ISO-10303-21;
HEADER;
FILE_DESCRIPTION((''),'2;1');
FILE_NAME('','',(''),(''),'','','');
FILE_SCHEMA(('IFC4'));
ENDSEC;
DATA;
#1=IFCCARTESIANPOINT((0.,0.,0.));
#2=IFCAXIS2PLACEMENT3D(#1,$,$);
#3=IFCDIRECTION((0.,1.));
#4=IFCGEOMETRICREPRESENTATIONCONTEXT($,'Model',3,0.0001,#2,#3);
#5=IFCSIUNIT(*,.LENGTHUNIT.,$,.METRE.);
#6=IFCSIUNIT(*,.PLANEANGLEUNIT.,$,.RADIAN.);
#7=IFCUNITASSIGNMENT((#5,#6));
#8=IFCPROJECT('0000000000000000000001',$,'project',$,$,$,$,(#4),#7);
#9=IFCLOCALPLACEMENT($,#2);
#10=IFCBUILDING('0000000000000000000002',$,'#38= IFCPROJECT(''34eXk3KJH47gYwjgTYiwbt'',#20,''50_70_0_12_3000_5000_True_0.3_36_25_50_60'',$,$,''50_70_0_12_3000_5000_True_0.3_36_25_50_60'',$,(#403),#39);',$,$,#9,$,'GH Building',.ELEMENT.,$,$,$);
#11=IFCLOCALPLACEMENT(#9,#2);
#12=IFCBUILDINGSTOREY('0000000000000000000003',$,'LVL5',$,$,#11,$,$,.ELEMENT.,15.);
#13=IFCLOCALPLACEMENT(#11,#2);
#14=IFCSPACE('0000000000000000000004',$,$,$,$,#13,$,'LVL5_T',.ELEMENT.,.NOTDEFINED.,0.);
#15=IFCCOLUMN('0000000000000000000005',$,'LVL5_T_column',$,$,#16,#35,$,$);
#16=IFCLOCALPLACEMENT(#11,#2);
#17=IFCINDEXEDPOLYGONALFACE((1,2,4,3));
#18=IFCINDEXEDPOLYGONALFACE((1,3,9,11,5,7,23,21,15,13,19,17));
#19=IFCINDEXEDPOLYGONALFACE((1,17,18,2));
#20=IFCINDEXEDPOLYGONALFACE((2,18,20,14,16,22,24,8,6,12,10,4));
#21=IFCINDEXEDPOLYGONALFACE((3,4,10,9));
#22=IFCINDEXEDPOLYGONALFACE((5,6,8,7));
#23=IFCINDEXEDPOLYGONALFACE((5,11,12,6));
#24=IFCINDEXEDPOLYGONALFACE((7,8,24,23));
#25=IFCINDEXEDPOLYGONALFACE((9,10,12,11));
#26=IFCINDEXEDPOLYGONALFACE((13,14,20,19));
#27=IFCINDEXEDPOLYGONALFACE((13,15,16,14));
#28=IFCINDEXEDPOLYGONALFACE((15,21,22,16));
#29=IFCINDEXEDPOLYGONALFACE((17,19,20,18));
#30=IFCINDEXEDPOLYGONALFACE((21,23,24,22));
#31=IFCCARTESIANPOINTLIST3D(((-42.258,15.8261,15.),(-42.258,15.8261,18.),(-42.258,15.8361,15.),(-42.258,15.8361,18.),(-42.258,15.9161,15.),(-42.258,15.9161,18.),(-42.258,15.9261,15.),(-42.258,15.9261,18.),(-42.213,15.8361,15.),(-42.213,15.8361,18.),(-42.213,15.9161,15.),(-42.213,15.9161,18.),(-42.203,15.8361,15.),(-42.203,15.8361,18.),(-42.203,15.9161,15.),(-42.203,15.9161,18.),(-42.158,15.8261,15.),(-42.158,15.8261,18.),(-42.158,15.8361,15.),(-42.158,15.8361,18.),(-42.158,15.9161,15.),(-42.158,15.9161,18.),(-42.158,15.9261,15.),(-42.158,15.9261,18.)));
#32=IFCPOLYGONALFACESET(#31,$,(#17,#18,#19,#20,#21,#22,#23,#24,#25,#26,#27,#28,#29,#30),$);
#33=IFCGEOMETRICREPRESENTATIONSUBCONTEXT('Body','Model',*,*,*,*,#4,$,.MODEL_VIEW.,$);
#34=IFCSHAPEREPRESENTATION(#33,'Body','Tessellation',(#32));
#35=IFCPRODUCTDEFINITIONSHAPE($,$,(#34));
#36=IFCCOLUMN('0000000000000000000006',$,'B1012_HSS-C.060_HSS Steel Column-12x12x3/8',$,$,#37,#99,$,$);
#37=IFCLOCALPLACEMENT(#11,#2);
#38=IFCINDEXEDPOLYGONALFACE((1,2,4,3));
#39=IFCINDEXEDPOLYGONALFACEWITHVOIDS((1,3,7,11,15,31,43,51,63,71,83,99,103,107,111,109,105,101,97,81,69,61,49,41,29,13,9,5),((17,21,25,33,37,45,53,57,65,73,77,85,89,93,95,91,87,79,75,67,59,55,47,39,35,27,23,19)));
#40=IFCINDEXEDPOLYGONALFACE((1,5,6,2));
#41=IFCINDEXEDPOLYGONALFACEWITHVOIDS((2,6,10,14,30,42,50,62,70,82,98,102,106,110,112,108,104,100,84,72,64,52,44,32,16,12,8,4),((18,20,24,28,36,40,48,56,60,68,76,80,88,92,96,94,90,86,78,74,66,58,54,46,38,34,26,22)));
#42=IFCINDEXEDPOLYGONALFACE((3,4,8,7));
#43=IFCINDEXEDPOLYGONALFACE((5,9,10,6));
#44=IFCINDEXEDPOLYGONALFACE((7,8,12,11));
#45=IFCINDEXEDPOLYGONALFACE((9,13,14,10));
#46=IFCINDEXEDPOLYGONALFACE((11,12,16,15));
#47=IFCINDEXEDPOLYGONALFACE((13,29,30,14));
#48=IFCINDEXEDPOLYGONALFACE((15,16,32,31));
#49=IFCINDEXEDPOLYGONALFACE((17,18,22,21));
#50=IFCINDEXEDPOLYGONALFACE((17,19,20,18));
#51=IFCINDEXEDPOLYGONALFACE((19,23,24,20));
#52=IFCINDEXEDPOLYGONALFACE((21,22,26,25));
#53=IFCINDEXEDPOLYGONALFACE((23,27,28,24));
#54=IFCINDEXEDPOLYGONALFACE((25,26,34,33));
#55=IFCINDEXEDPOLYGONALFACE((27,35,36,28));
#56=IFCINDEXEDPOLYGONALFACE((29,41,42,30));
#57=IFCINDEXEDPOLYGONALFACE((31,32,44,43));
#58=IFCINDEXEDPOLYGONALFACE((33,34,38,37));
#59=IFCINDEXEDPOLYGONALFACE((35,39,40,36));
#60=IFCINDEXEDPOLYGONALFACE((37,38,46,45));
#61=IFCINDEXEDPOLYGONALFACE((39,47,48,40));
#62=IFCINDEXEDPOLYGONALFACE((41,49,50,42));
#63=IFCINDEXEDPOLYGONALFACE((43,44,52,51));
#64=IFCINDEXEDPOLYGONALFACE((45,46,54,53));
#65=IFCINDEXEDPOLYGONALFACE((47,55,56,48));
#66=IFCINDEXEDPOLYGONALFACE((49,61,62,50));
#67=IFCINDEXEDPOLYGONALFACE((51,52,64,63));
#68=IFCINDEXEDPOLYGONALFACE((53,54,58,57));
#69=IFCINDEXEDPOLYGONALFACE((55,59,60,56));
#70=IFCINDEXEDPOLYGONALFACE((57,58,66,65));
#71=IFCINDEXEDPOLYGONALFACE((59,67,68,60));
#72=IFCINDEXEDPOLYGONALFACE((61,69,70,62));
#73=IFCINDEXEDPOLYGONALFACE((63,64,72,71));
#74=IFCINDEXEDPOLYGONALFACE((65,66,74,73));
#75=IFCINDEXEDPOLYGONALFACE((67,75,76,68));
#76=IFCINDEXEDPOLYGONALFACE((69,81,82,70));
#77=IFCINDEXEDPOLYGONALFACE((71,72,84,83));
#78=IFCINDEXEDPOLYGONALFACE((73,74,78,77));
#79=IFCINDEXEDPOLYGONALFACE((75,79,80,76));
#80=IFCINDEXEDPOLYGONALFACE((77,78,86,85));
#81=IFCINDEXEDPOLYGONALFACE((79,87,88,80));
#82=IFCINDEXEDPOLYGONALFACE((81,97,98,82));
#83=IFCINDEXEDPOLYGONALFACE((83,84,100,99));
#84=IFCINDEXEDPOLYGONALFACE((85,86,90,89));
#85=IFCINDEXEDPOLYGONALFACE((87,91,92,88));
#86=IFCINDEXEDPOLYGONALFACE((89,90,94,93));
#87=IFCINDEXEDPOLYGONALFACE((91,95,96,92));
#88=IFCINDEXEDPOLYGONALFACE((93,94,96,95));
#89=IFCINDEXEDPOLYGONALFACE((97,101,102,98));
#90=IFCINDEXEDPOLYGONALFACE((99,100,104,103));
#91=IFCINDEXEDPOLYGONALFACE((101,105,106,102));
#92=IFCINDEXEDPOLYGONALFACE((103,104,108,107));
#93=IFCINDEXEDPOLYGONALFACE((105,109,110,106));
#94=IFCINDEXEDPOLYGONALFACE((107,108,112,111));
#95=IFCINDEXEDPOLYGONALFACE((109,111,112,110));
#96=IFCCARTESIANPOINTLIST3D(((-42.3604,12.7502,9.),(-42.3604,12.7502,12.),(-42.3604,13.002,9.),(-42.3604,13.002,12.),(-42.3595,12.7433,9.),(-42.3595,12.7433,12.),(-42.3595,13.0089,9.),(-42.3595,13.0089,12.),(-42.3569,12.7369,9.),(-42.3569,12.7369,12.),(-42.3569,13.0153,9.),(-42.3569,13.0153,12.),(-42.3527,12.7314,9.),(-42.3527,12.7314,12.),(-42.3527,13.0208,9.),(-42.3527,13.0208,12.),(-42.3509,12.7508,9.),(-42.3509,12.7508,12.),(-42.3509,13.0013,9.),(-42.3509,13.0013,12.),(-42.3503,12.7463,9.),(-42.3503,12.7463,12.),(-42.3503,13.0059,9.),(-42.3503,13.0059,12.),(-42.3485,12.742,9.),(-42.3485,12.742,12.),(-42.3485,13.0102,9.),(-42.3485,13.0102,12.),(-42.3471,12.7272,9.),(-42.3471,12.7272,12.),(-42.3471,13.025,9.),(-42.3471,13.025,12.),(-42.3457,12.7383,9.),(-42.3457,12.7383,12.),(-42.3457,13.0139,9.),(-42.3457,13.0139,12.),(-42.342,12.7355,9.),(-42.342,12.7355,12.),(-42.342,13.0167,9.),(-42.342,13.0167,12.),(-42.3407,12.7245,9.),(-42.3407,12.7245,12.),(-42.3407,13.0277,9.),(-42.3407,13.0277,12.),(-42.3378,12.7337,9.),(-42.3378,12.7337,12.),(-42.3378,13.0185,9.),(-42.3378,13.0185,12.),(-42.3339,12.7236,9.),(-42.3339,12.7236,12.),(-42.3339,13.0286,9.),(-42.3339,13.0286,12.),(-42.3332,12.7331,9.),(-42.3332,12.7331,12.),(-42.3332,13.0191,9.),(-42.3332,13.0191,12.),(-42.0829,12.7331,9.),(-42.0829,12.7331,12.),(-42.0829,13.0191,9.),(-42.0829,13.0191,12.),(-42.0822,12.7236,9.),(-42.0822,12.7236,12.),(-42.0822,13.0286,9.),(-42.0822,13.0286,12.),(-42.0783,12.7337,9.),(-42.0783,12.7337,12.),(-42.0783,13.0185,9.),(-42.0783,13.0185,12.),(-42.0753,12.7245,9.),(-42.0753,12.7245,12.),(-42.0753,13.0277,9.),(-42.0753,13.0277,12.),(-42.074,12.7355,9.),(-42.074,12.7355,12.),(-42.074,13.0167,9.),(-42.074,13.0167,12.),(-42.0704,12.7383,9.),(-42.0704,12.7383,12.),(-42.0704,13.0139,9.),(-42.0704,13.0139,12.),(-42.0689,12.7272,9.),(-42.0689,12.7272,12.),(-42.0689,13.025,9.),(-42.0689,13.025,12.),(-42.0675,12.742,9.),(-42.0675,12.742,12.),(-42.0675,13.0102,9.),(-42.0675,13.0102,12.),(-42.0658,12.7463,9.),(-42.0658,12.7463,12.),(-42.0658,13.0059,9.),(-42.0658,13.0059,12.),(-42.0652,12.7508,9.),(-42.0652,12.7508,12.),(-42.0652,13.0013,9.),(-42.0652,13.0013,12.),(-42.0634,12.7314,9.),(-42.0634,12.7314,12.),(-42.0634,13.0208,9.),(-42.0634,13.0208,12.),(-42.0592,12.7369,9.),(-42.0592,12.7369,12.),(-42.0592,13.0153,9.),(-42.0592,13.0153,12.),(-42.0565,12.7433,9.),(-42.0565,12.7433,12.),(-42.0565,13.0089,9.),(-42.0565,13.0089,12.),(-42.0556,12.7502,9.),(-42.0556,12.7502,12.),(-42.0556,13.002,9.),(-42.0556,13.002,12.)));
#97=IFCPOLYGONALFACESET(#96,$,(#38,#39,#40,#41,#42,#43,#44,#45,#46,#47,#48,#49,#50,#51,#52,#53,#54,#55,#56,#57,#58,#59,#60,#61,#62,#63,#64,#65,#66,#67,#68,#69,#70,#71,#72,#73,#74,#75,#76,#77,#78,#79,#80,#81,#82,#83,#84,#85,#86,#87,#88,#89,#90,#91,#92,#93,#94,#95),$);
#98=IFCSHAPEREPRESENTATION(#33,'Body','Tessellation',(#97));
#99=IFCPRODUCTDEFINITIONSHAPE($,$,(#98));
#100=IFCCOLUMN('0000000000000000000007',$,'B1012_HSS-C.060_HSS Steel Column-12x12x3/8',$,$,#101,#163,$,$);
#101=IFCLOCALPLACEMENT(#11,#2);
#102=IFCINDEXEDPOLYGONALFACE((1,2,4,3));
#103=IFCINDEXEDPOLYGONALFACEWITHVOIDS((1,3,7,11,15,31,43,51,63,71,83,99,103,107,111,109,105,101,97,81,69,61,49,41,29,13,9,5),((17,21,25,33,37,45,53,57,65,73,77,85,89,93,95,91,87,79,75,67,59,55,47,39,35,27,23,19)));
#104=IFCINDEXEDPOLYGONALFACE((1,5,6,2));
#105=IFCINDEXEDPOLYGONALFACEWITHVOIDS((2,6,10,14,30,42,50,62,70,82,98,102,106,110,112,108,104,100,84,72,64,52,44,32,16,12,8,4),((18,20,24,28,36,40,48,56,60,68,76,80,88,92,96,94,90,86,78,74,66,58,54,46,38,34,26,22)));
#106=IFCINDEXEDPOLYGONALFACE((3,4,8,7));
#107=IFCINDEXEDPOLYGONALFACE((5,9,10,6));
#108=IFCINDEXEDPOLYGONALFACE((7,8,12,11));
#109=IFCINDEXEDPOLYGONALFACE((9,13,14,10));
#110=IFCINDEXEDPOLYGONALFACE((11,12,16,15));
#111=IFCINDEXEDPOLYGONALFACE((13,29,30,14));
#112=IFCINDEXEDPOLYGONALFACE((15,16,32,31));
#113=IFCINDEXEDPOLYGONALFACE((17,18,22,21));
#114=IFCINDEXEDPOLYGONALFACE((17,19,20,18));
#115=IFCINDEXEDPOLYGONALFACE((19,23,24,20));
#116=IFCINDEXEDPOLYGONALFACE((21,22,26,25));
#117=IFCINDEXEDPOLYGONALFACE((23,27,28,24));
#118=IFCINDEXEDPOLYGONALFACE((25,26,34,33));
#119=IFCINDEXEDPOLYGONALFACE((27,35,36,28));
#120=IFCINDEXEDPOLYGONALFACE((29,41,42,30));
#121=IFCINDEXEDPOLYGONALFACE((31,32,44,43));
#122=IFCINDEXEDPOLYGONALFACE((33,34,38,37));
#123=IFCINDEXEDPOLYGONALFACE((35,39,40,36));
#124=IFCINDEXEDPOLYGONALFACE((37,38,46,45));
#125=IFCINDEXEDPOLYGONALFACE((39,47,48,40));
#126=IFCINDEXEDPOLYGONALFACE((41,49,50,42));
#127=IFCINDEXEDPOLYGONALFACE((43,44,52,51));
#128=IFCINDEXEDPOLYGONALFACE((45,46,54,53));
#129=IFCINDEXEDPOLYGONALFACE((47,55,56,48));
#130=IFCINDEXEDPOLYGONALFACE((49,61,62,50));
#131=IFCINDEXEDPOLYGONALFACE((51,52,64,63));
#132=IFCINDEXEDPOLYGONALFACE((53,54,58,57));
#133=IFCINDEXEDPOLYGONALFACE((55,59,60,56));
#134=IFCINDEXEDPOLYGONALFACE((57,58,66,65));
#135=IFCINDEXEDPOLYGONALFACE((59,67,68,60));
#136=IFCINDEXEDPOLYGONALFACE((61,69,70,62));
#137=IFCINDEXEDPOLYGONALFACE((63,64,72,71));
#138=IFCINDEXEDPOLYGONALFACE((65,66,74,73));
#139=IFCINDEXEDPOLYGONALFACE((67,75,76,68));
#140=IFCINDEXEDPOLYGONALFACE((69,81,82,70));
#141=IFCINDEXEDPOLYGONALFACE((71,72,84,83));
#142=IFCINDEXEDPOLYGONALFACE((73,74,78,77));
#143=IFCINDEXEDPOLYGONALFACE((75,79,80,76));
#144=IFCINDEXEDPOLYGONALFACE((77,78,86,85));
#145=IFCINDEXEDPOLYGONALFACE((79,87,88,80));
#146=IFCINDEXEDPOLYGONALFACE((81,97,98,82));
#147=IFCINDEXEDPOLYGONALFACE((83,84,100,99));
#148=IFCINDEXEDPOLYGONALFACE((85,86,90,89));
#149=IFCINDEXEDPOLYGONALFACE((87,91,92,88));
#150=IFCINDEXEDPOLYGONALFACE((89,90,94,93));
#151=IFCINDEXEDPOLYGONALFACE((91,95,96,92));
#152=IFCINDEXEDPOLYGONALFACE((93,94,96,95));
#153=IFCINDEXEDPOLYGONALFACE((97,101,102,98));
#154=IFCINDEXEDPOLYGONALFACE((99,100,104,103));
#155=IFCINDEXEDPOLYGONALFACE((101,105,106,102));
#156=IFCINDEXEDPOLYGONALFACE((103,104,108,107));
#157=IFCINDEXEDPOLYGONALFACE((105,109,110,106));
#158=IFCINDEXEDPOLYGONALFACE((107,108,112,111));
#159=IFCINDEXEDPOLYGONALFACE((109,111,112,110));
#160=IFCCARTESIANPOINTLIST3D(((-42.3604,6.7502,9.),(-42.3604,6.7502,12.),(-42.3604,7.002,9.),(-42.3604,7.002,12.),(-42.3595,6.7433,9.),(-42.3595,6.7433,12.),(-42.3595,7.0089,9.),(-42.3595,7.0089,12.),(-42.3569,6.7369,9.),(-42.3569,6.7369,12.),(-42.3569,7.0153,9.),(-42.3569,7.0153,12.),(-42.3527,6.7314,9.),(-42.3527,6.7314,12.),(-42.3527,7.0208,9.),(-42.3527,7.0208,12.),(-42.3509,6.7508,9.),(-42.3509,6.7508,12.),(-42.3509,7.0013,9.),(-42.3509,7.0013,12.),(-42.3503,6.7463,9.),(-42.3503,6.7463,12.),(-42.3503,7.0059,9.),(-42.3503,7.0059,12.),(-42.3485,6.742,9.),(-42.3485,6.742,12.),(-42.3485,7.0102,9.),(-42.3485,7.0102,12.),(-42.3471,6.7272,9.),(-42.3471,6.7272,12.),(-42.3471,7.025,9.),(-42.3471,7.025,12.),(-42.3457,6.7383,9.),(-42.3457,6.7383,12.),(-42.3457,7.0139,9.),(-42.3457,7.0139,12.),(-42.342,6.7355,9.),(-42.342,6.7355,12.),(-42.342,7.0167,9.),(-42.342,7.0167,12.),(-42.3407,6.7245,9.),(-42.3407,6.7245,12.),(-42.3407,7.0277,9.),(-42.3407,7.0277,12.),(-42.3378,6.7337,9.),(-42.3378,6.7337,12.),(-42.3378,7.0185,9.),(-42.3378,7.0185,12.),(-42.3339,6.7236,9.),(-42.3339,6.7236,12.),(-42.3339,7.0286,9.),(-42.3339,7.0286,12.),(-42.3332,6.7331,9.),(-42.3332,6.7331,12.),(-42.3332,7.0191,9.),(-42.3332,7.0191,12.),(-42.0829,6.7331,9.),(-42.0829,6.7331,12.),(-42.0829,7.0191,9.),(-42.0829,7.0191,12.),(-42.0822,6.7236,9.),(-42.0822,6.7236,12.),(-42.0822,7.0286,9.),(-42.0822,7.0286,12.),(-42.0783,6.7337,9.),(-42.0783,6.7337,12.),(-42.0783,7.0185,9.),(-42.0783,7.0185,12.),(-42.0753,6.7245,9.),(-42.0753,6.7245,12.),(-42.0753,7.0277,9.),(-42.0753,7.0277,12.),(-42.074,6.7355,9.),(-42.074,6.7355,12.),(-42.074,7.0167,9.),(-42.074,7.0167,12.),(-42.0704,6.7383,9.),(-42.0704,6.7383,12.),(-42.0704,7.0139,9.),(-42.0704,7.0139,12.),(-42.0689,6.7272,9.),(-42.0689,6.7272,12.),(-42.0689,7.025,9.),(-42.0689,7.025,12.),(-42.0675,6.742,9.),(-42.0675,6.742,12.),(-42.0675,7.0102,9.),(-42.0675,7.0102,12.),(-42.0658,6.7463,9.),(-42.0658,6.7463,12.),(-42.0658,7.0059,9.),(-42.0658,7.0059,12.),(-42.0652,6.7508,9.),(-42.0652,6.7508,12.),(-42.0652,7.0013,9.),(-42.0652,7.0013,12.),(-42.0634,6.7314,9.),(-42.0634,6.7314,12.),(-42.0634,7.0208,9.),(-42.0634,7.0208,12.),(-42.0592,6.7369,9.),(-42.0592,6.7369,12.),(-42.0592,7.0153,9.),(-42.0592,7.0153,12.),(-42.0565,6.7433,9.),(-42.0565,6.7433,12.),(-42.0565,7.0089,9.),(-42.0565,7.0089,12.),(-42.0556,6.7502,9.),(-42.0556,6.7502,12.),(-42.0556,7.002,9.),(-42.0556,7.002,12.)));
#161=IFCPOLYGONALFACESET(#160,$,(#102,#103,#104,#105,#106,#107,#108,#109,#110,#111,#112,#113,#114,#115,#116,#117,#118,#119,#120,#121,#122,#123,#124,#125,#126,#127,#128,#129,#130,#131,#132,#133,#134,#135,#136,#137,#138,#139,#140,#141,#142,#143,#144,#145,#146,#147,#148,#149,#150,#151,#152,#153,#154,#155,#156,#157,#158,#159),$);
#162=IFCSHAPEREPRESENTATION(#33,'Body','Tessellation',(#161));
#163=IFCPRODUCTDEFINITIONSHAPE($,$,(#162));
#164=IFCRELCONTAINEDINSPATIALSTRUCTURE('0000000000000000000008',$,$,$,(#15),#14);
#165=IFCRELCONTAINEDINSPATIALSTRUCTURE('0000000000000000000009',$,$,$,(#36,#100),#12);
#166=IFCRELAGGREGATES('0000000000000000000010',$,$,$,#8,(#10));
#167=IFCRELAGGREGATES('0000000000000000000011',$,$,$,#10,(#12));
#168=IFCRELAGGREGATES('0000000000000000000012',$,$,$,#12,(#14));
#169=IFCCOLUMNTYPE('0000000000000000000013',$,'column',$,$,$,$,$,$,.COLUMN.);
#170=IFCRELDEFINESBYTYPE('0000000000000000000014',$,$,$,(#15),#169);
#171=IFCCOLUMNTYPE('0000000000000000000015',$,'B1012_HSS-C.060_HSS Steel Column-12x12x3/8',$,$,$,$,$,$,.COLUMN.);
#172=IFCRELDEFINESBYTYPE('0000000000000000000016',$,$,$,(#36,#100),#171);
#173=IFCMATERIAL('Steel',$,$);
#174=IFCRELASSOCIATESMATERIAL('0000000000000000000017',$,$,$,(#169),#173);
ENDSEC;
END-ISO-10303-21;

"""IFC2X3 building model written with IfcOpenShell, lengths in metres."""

from ifc_helpers import new_model, si_unit, direction, frame, origin, origin_2d, place, context, subcontext, project, spatial, hollow_rectangle, i_section, extrude, material, type_object, element, save


model = new_model("IFC2X3")

# Units and contexts
model_context = context("Model", 3, precision=0.0001, world=origin(), true_north=direction((0.0, 1.0)))
body_context = subcontext(model_context, "Body", "Model", "MODEL_VIEW")
ifc_project = project(units=[si_unit("LENGTHUNIT", "METRE"), si_unit("PLANEANGLEUNIT", "RADIAN")], contexts=[model_context])

# Building, storey, space
building_placement = place(None, origin())
building = spatial("IfcBuilding", under=ifc_project, at=building_placement, Name="#38= IFCPROJECT('34eXk3KJH47gYwjgTYiwbt',#20,'50_70_0_12_3000_5000_True_0.3_36_25_50_60',$,$,'50_70_0_12_3000_5000_True_0.3_36_25_50_60',$,(#403),#39);", LongName="GH Building", CompositionType="ELEMENT")
storey_placement = place(building_placement, origin())
storey = spatial("IfcBuildingStorey", under=building, at=storey_placement, Name="LVL5", CompositionType="ELEMENT", Elevation=15.0)
space_1_placement = place(storey_placement, origin())
space_1 = spatial("IfcSpace", under=storey, at=space_1_placement, LongName="LVL5_T", CompositionType="ELEMENT", InteriorOrExteriorSpace="NOTDEFINED", ElevationWithFlooring=0.0)

# Column
ifc_material_1 = material(Name="Steel")
column_type_1 = type_object("IfcColumnType", Name="column", PredefinedType="COLUMN", material=ifc_material_1)
column_1_placement = place(space_1_placement, frame((-42.208, 15.8761, 15.0)))
element("IfcColumn", 1, at=column_1_placement, inside=space_1, type_object=column_type_1, Name="LVL5_T_column", context=body_context, shape_type="SweptSolid", body=[
    extrude(i_section(OverallWidth=0.1, OverallDepth=0.1, WebThickness=0.01, FlangeThickness=0.01, at=origin_2d()), origin(), (0.0, 0.0, 1.0), 3.0),
])

# Columns
column_type_2 = type_object("IfcColumnType", Name="B1012_HSS-C.060_HSS Steel Column-12x12x3/8", PredefinedType="COLUMN")
for number, where, z_axis, x_axis, name in (
    (2, (-42.208, 12.8761, 12.0), (0.0, 0.0, -1.0), (-1.0, 0.0, 0.0), "B1012_HSS-C.060_HSS Steel Column-12x12x3/8"),
    (3, (-42.208, 6.8761, 12.0), (0.0, 0.0, -1.0), (-1.0, 0.0, 0.0), "B1012_HSS-C.060_HSS Steel Column-12x12x3/8"),
):
    element("IfcColumn", number, at=place(storey_placement, frame(where, z_axis=z_axis, x_axis=x_axis)), inside=storey, type_object=column_type_2, Name=name, context=body_context, shape_type="SweptSolid", body=[
        extrude(hollow_rectangle(XDim=0.3048, YDim=0.305, WallThickness=0.0095, InnerFilletRadius=0.0177, OuterFilletRadius=0.0266, at=origin_2d()), origin(), (0.0, 0.0, 1.0), 3.0),
    ])

save(model, "model.ifc")
